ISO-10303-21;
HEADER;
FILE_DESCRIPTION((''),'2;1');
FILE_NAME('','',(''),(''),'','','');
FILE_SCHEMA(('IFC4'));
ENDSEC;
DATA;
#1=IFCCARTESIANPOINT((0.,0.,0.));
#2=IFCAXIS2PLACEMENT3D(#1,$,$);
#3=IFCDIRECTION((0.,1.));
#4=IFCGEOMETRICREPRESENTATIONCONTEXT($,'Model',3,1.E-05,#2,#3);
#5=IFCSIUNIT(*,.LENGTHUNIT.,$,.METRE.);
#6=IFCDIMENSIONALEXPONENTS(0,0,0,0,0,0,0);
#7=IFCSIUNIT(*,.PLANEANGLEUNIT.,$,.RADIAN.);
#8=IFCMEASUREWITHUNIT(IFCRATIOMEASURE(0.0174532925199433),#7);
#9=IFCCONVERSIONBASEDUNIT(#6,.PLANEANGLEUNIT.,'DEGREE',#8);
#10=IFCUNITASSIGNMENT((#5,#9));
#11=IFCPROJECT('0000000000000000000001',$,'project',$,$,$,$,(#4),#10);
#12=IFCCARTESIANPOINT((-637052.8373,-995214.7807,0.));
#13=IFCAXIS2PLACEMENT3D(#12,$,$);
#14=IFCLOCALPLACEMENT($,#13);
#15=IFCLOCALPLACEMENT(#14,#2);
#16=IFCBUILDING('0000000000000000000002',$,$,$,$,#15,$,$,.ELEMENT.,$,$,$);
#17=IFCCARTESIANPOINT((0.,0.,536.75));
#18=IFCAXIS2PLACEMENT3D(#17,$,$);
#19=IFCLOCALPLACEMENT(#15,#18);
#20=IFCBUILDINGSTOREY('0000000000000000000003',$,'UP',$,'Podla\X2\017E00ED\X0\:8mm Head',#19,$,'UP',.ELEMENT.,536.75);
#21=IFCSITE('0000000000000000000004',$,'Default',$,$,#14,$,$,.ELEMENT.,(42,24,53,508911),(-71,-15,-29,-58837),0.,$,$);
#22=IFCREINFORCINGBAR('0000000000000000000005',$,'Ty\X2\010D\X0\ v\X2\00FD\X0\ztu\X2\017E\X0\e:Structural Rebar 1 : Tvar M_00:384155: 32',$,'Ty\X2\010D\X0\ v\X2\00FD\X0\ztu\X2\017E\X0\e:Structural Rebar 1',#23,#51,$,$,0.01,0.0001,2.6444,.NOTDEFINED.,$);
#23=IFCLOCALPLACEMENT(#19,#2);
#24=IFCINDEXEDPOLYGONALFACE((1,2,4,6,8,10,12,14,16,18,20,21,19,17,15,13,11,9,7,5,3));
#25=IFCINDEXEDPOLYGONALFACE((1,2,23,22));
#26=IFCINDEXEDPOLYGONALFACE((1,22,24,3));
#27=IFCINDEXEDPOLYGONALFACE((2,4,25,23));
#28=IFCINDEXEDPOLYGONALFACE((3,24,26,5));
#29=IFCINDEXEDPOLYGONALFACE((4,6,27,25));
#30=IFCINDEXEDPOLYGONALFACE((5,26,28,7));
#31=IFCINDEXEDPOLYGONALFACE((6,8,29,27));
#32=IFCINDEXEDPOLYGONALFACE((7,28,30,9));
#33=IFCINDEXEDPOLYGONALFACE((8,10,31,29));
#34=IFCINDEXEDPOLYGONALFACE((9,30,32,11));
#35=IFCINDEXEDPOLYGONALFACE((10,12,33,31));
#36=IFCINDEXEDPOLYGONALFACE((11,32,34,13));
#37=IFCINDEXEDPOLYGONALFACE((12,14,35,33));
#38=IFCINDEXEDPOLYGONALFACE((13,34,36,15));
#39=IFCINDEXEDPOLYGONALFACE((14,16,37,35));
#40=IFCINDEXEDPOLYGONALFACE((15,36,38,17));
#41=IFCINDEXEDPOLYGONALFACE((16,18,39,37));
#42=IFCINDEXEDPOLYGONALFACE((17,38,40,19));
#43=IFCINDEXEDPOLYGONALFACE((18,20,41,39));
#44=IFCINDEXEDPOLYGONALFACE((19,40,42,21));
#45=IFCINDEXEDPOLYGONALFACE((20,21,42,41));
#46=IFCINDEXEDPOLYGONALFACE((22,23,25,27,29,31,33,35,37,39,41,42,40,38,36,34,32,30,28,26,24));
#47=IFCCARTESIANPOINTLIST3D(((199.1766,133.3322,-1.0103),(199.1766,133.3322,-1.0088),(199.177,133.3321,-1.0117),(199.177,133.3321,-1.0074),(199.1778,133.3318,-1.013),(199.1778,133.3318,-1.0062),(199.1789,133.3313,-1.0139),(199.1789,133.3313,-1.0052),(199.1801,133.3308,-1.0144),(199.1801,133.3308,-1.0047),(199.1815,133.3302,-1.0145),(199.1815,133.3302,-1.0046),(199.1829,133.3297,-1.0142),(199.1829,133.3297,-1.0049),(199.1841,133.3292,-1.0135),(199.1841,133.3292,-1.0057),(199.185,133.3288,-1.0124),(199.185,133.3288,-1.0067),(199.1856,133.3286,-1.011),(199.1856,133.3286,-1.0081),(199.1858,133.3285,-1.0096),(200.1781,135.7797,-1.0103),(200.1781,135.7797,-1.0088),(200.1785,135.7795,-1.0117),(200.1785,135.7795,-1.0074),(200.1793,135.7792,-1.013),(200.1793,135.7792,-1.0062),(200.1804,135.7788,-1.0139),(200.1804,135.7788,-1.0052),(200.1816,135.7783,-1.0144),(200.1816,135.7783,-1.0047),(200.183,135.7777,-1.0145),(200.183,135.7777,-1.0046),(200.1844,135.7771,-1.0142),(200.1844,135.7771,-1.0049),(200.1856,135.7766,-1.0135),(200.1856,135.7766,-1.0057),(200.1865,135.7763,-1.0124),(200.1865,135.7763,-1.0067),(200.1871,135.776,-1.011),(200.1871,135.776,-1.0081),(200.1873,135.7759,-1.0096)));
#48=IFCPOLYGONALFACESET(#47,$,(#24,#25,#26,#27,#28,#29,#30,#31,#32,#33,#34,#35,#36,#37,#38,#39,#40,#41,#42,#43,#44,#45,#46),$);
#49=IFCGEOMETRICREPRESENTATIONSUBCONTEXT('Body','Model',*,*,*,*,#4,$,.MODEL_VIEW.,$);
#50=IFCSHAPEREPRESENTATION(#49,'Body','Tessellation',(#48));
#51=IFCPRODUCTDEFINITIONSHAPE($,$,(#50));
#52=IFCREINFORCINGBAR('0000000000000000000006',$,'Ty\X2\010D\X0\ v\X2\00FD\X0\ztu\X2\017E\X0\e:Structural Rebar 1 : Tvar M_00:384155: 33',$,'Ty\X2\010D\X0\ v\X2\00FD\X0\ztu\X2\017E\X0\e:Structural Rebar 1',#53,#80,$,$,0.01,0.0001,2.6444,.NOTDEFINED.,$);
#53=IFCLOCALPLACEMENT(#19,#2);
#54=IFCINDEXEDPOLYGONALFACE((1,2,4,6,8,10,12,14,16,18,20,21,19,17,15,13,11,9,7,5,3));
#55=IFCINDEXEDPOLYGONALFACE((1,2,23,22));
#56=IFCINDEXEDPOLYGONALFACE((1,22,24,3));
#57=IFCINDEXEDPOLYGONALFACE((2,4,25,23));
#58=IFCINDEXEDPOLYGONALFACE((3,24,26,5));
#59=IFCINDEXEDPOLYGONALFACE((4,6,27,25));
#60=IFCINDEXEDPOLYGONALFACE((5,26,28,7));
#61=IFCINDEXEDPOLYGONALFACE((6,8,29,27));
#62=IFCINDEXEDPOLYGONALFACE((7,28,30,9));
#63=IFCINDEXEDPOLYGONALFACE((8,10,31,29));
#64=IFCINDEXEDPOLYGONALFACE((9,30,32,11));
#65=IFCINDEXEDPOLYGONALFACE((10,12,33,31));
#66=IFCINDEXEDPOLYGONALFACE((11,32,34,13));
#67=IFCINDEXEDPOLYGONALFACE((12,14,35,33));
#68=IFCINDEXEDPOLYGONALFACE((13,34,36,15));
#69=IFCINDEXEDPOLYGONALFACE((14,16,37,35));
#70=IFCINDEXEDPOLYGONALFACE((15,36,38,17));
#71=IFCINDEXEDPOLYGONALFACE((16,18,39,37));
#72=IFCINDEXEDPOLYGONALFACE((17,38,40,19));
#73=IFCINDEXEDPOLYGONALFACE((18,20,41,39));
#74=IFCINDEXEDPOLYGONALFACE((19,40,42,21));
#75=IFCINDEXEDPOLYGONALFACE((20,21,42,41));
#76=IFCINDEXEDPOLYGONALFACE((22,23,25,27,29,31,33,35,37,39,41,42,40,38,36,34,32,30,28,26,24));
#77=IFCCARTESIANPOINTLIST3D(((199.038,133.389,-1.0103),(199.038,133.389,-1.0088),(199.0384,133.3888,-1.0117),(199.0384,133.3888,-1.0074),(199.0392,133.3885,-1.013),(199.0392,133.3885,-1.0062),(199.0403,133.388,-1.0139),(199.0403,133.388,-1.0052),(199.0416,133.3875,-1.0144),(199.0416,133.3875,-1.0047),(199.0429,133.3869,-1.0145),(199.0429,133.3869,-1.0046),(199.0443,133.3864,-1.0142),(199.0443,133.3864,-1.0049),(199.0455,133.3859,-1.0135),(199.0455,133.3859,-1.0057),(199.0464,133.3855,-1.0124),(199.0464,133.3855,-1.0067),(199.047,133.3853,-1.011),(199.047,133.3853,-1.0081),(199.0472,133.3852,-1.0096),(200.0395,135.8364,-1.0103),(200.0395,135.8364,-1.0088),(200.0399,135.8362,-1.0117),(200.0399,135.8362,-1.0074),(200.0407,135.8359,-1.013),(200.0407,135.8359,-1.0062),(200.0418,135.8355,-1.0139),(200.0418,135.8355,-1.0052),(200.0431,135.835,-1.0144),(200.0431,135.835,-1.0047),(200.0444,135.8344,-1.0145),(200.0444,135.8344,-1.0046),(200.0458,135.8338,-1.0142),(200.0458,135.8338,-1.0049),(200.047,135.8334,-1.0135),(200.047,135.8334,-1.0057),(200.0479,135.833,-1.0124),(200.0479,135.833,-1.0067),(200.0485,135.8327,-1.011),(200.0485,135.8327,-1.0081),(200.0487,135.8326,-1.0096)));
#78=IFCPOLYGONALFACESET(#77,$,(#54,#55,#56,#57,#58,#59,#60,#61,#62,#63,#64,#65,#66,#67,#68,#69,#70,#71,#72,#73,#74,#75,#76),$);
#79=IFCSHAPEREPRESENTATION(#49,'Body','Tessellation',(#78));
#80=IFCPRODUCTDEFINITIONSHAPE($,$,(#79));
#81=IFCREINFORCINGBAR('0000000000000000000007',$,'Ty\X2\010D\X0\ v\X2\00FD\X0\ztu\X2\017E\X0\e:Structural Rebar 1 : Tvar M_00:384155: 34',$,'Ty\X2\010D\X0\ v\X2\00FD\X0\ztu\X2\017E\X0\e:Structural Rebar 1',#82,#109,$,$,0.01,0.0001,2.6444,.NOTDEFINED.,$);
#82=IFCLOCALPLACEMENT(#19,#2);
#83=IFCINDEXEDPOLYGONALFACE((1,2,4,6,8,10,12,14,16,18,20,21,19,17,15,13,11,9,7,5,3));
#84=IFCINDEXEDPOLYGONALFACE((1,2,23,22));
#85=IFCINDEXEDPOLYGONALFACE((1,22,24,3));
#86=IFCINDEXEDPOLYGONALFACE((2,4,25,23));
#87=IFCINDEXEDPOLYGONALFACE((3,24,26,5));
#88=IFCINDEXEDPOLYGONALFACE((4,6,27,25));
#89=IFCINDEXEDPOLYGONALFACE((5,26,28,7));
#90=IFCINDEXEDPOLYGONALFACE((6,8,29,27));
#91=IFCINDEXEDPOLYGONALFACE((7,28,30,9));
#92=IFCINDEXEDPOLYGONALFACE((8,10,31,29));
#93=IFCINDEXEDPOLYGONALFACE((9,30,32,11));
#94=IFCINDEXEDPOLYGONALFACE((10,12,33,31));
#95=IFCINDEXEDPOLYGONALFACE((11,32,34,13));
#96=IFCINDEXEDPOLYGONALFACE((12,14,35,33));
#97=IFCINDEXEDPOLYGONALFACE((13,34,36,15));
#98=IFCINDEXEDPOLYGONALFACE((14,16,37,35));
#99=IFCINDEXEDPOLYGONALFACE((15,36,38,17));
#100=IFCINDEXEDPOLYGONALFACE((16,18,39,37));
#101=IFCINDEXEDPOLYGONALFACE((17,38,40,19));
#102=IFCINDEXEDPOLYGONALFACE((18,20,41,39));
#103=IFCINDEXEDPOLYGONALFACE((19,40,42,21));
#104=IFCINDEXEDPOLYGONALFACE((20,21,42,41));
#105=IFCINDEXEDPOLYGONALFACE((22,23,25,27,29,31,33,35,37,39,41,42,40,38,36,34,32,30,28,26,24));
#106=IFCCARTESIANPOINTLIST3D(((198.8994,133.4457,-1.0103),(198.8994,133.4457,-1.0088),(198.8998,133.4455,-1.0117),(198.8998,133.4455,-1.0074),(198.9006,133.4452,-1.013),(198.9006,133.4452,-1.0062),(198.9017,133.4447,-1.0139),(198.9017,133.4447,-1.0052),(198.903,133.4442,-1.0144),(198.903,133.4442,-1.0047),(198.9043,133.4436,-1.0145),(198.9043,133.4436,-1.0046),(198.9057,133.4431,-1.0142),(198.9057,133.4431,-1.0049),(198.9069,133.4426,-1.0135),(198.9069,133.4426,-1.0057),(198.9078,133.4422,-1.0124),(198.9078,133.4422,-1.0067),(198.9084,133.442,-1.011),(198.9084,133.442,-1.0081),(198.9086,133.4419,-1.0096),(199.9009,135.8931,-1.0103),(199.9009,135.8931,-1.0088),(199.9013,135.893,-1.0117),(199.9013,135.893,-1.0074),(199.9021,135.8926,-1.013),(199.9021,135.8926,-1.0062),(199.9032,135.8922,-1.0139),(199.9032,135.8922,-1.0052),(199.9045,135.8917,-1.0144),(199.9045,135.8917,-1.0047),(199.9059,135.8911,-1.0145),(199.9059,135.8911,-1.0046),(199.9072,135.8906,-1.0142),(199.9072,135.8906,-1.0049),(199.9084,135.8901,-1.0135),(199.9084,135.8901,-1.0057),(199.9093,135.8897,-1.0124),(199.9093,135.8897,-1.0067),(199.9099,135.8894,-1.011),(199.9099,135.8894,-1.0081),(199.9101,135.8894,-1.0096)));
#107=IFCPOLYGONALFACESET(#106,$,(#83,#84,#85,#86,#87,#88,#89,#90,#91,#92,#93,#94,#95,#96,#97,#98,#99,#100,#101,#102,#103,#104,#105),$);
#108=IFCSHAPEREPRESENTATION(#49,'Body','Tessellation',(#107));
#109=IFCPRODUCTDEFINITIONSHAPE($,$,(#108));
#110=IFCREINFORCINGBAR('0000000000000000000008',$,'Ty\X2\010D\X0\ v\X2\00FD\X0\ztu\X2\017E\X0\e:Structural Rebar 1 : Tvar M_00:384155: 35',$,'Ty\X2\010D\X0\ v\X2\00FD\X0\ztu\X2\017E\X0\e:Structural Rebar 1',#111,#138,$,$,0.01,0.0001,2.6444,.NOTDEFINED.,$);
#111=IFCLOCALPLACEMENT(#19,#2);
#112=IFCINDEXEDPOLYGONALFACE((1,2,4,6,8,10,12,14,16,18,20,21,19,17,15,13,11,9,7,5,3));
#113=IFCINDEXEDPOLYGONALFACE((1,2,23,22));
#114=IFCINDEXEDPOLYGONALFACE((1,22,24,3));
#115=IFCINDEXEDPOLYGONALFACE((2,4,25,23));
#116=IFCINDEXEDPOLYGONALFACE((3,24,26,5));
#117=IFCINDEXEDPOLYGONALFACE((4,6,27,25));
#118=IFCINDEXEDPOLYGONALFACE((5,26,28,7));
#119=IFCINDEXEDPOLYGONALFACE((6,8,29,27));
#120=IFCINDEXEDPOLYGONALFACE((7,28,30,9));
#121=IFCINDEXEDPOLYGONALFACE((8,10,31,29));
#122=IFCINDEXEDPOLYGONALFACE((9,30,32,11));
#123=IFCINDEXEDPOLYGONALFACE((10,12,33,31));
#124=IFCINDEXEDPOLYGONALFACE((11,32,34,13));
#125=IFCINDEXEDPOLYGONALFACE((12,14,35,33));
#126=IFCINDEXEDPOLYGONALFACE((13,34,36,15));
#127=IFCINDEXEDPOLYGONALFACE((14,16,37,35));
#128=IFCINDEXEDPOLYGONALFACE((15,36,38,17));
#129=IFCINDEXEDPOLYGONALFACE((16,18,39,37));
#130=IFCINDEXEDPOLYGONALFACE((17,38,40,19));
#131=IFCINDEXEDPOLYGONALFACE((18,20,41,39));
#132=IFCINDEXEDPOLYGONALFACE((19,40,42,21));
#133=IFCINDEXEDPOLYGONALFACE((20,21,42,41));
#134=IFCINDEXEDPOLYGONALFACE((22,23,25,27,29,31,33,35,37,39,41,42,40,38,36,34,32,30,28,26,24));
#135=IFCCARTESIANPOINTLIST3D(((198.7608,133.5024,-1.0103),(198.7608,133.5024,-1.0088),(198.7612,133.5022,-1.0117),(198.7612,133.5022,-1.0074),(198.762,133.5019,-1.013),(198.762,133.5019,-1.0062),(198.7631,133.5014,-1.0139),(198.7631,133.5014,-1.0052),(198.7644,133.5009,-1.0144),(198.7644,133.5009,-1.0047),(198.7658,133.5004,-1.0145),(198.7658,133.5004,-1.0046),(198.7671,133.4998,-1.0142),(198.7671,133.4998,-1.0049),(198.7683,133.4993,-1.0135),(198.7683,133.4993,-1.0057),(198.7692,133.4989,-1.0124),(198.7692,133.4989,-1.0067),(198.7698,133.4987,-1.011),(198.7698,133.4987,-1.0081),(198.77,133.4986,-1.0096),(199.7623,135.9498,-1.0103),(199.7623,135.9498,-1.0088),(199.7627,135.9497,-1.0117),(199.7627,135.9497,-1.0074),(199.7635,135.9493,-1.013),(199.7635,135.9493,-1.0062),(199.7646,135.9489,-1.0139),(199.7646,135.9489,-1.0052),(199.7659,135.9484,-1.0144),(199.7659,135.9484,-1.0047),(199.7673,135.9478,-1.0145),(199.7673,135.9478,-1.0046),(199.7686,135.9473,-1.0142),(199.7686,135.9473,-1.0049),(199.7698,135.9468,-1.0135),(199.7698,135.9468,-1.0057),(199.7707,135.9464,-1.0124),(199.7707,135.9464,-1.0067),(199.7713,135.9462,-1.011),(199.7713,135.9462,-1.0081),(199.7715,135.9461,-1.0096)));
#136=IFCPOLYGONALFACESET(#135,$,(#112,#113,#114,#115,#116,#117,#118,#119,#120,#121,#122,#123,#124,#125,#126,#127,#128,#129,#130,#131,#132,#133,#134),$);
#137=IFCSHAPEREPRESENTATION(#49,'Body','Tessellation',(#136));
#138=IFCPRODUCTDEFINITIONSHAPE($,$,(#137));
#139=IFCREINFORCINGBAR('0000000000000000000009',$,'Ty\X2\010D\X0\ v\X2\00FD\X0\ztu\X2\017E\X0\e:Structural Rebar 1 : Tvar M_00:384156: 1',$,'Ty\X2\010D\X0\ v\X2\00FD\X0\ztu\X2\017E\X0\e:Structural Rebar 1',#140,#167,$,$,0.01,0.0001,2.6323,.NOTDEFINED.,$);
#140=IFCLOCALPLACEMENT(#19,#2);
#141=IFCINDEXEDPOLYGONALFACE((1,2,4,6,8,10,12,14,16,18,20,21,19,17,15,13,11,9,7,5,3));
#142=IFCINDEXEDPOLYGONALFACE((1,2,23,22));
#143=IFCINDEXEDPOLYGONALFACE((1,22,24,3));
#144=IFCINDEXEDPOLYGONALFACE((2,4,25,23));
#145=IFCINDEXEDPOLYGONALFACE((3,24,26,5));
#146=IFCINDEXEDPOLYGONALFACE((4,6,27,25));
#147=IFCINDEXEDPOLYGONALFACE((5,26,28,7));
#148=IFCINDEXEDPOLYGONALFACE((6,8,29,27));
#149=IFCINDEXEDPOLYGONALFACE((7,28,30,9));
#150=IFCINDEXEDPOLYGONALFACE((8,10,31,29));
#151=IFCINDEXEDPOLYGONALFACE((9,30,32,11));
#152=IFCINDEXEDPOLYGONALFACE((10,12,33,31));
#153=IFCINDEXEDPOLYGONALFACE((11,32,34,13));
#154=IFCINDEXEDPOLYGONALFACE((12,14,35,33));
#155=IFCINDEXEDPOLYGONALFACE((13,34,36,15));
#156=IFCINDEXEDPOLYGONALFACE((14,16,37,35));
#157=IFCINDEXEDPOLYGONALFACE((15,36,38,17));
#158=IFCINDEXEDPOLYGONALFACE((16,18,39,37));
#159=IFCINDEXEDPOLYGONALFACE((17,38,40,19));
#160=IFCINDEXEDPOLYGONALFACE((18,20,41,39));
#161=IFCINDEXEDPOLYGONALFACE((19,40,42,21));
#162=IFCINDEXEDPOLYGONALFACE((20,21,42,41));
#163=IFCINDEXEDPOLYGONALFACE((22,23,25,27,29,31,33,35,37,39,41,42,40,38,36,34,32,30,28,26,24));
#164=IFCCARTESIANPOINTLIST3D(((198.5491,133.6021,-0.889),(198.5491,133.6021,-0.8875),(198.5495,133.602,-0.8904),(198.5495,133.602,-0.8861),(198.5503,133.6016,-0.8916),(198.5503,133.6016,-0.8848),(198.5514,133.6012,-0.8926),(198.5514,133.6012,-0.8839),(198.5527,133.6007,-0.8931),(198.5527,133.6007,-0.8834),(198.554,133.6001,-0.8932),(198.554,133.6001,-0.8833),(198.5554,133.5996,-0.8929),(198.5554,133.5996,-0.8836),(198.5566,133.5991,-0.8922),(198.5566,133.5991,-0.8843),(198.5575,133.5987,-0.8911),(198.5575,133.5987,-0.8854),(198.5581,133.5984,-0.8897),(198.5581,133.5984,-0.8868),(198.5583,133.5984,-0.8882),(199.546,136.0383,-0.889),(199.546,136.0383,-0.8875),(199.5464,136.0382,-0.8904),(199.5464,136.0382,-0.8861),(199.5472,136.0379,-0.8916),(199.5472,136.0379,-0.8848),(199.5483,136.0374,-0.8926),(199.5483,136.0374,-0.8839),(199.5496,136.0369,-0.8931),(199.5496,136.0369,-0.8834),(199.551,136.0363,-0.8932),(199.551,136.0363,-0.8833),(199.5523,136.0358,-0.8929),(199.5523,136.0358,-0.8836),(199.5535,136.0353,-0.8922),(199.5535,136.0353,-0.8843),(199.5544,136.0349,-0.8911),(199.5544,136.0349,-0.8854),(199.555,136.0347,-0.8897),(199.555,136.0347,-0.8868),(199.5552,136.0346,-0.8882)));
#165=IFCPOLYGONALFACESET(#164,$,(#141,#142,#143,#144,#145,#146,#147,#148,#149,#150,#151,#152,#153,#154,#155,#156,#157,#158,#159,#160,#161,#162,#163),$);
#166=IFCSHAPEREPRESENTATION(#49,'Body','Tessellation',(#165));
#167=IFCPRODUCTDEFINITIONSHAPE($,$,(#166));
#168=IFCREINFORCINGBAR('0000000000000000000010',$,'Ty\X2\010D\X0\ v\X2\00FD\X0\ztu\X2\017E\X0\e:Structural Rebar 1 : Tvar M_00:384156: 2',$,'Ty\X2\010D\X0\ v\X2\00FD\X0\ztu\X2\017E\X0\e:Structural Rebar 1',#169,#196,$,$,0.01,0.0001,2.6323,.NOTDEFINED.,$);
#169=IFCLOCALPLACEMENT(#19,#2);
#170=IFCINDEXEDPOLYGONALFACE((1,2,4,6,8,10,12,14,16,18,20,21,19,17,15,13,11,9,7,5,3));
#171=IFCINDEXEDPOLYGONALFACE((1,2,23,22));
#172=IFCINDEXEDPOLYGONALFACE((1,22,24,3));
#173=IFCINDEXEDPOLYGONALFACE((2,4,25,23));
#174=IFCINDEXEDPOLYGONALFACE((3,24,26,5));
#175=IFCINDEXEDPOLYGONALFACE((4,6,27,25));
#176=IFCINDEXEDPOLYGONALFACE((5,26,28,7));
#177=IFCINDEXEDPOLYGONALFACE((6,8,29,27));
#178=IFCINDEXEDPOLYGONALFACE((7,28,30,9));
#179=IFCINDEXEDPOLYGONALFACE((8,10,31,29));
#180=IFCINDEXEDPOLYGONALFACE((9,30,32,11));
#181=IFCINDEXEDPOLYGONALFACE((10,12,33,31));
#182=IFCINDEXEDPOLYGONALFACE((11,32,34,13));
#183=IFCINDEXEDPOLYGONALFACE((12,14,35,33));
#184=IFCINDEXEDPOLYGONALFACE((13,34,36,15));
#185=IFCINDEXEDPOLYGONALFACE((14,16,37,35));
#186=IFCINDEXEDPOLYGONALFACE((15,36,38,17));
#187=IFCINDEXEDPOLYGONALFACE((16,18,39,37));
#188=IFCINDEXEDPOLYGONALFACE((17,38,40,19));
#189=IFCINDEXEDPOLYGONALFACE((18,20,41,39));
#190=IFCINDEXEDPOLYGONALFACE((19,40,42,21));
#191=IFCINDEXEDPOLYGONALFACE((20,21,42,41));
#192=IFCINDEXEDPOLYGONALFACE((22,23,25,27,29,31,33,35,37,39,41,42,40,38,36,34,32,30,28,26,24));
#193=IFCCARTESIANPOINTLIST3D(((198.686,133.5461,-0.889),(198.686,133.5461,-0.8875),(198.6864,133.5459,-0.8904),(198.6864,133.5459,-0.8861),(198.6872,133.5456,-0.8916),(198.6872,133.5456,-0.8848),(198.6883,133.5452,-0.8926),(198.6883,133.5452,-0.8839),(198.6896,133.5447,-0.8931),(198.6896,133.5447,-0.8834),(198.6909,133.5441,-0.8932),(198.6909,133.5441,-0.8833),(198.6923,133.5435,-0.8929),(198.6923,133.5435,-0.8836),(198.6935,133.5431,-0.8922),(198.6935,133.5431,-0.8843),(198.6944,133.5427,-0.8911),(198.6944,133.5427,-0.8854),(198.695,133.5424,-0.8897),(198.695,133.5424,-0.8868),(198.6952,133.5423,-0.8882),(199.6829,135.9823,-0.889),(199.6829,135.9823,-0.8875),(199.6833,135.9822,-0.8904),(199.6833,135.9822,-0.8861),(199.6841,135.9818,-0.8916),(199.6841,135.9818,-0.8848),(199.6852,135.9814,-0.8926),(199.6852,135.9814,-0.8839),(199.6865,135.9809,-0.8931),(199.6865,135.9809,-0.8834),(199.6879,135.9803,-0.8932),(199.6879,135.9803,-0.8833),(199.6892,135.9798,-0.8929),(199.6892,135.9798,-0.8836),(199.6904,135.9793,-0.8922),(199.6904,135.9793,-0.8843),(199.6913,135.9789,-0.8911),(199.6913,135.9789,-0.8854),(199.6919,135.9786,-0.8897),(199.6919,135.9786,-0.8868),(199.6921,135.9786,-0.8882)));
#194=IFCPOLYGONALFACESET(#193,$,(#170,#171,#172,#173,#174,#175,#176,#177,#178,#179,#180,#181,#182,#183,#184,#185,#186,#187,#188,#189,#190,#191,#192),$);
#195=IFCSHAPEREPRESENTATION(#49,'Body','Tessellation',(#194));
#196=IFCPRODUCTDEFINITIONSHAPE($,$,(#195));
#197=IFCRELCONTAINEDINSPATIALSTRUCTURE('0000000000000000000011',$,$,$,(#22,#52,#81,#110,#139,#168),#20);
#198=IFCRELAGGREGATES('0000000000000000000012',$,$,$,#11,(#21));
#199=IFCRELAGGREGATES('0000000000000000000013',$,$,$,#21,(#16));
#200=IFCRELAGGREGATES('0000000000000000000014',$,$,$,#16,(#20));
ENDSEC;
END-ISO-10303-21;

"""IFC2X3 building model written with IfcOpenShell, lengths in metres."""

from ifc_helpers import new_model, entity, si_unit, converted_unit, direction, frame, origin, place, context, subcontext, project, spatial, element, save


model = new_model("IFC2X3")

# Units and contexts
model_context = context("Model", 3, precision=1e-05, world=origin(), true_north=direction((0.0, 1.0)))
body_context = subcontext(model_context, "Body", "Model", "MODEL_VIEW")
ifc_project = project(units=[si_unit("LENGTHUNIT", "METRE"), converted_unit("PLANEANGLEUNIT", "DEGREE", entity("IfcRatioMeasure", 0.0174532925199433), si_unit("PLANEANGLEUNIT", "RADIAN"), dimensions=[0, 0, 0, 0, 0, 0, 0])], contexts=[model_context])

# Site, building, storey
site_placement = place(None, frame((-637052.8373, -995214.7807, 0.0)))
site = spatial("IfcSite", under=ifc_project, at=site_placement, Name="Default", CompositionType="ELEMENT", RefLatitude=(42, 24, 53, 508911), RefLongitude=(-71, -15, -29, -58837), RefElevation=0.0)
building_placement = place(site_placement, origin())
building = spatial("IfcBuilding", under=site, at=building_placement, CompositionType="ELEMENT")
storey_placement = place(building_placement, frame((0.0, 0.0, 536.75)))
storey = spatial("IfcBuildingStorey", under=building, at=storey_placement, Name="UP", ObjectType="Podlaží:8mm Head", LongName="UP", CompositionType="ELEMENT", Elevation=536.75)

# Reinforcing bars
reinforcing_bar_1_placement = place(storey_placement, origin())
element("IfcReinforcingBar", 1, at=reinforcing_bar_1_placement, inside=storey, Name="Tyč výztuže:Structural Rebar 1 : Tvar M_00:384155: 32", ObjectType="Tyč výztuže:Structural Rebar 1", BarLength=2.6444, BarRole="NOTDEFINED", CrossSectionArea=0.0001, NominalDiameter=0.01, context=body_context, shape_type="AdvancedSweptSolid", body=[
    entity("IfcSweptDiskSolid", entity("IfcCompositeCurve", [entity("IfcCompositeCurveSegment", "CONTINUOUS", True, entity("IfcPolyline", [entity("IfcCartesianPoint", [-200.1827, -135.7778, 1.0096]), entity("IfcCartesianPoint", [-199.1812, -133.3304, 1.0096])]))], False), 0.005, None, 0.0, 1.0),
])
reinforcing_bar_2_placement = place(storey_placement, origin())
element("IfcReinforcingBar", 2, at=reinforcing_bar_2_placement, inside=storey, Name="Tyč výztuže:Structural Rebar 1 : Tvar M_00:384155: 33", ObjectType="Tyč výztuže:Structural Rebar 1", BarLength=2.6444, BarRole="NOTDEFINED", CrossSectionArea=0.0001, NominalDiameter=0.01, context=body_context, shape_type="AdvancedSweptSolid", body=[
    entity("IfcSweptDiskSolid", entity("IfcCompositeCurve", [entity("IfcCompositeCurveSegment", "CONTINUOUS", True, entity("IfcPolyline", [entity("IfcCartesianPoint", [-200.0441, -135.8345, 1.0096]), entity("IfcCartesianPoint", [-199.0426, -133.3871, 1.0096])]))], False), 0.005, None, 0.0, 1.0),
])
reinforcing_bar_3_placement = place(storey_placement, origin())
element("IfcReinforcingBar", 3, at=reinforcing_bar_3_placement, inside=storey, Name="Tyč výztuže:Structural Rebar 1 : Tvar M_00:384155: 34", ObjectType="Tyč výztuže:Structural Rebar 1", BarLength=2.6444, BarRole="NOTDEFINED", CrossSectionArea=0.0001, NominalDiameter=0.01, context=body_context, shape_type="AdvancedSweptSolid", body=[
    entity("IfcSweptDiskSolid", entity("IfcCompositeCurve", [entity("IfcCompositeCurveSegment", "CONTINUOUS", True, entity("IfcPolyline", [entity("IfcCartesianPoint", [-199.9055, -135.8913, 1.0096]), entity("IfcCartesianPoint", [-198.904, -133.4438, 1.0096])]))], False), 0.005, None, 0.0, 1.0),
])
reinforcing_bar_4_placement = place(storey_placement, origin())
element("IfcReinforcingBar", 4, at=reinforcing_bar_4_placement, inside=storey, Name="Tyč výztuže:Structural Rebar 1 : Tvar M_00:384155: 35", ObjectType="Tyč výztuže:Structural Rebar 1", BarLength=2.6444, BarRole="NOTDEFINED", CrossSectionArea=0.0001, NominalDiameter=0.01, context=body_context, shape_type="AdvancedSweptSolid", body=[
    entity("IfcSweptDiskSolid", entity("IfcCompositeCurve", [entity("IfcCompositeCurveSegment", "CONTINUOUS", True, entity("IfcPolyline", [entity("IfcCartesianPoint", [-199.7669, -135.948, 1.0096]), entity("IfcCartesianPoint", [-198.7654, -133.5005, 1.0096])]))], False), 0.005, None, 0.0, 1.0),
])
reinforcing_bar_5_placement = place(storey_placement, origin())
element("IfcReinforcingBar", 5, at=reinforcing_bar_5_placement, inside=storey, Name="Tyč výztuže:Structural Rebar 1 : Tvar M_00:384156: 1", ObjectType="Tyč výztuže:Structural Rebar 1", BarLength=2.6323, BarRole="NOTDEFINED", CrossSectionArea=0.0001, NominalDiameter=0.01, context=body_context, shape_type="AdvancedSweptSolid", body=[
    entity("IfcSweptDiskSolid", entity("IfcCompositeCurve", [entity("IfcCompositeCurveSegment", "CONTINUOUS", True, entity("IfcPolyline", [entity("IfcCartesianPoint", [-199.5506, -136.0365, 0.8882]), entity("IfcCartesianPoint", [-198.5537, -133.6003, 0.8882])]))], False), 0.005, None, 0.0, 1.0),
])
reinforcing_bar_6_placement = place(storey_placement, origin())
element("IfcReinforcingBar", 6, at=reinforcing_bar_6_placement, inside=storey, Name="Tyč výztuže:Structural Rebar 1 : Tvar M_00:384156: 2", ObjectType="Tyč výztuže:Structural Rebar 1", BarLength=2.6323, BarRole="NOTDEFINED", CrossSectionArea=0.0001, NominalDiameter=0.01, context=body_context, shape_type="AdvancedSweptSolid", body=[
    entity("IfcSweptDiskSolid", entity("IfcCompositeCurve", [entity("IfcCompositeCurveSegment", "CONTINUOUS", True, entity("IfcPolyline", [entity("IfcCartesianPoint", [-199.6875, -135.9805, 0.8882]), entity("IfcCartesianPoint", [-198.6906, -133.5442, 0.8882])]))], False), 0.005, None, 0.0, 1.0),
])

save(model, "model.ifc")
